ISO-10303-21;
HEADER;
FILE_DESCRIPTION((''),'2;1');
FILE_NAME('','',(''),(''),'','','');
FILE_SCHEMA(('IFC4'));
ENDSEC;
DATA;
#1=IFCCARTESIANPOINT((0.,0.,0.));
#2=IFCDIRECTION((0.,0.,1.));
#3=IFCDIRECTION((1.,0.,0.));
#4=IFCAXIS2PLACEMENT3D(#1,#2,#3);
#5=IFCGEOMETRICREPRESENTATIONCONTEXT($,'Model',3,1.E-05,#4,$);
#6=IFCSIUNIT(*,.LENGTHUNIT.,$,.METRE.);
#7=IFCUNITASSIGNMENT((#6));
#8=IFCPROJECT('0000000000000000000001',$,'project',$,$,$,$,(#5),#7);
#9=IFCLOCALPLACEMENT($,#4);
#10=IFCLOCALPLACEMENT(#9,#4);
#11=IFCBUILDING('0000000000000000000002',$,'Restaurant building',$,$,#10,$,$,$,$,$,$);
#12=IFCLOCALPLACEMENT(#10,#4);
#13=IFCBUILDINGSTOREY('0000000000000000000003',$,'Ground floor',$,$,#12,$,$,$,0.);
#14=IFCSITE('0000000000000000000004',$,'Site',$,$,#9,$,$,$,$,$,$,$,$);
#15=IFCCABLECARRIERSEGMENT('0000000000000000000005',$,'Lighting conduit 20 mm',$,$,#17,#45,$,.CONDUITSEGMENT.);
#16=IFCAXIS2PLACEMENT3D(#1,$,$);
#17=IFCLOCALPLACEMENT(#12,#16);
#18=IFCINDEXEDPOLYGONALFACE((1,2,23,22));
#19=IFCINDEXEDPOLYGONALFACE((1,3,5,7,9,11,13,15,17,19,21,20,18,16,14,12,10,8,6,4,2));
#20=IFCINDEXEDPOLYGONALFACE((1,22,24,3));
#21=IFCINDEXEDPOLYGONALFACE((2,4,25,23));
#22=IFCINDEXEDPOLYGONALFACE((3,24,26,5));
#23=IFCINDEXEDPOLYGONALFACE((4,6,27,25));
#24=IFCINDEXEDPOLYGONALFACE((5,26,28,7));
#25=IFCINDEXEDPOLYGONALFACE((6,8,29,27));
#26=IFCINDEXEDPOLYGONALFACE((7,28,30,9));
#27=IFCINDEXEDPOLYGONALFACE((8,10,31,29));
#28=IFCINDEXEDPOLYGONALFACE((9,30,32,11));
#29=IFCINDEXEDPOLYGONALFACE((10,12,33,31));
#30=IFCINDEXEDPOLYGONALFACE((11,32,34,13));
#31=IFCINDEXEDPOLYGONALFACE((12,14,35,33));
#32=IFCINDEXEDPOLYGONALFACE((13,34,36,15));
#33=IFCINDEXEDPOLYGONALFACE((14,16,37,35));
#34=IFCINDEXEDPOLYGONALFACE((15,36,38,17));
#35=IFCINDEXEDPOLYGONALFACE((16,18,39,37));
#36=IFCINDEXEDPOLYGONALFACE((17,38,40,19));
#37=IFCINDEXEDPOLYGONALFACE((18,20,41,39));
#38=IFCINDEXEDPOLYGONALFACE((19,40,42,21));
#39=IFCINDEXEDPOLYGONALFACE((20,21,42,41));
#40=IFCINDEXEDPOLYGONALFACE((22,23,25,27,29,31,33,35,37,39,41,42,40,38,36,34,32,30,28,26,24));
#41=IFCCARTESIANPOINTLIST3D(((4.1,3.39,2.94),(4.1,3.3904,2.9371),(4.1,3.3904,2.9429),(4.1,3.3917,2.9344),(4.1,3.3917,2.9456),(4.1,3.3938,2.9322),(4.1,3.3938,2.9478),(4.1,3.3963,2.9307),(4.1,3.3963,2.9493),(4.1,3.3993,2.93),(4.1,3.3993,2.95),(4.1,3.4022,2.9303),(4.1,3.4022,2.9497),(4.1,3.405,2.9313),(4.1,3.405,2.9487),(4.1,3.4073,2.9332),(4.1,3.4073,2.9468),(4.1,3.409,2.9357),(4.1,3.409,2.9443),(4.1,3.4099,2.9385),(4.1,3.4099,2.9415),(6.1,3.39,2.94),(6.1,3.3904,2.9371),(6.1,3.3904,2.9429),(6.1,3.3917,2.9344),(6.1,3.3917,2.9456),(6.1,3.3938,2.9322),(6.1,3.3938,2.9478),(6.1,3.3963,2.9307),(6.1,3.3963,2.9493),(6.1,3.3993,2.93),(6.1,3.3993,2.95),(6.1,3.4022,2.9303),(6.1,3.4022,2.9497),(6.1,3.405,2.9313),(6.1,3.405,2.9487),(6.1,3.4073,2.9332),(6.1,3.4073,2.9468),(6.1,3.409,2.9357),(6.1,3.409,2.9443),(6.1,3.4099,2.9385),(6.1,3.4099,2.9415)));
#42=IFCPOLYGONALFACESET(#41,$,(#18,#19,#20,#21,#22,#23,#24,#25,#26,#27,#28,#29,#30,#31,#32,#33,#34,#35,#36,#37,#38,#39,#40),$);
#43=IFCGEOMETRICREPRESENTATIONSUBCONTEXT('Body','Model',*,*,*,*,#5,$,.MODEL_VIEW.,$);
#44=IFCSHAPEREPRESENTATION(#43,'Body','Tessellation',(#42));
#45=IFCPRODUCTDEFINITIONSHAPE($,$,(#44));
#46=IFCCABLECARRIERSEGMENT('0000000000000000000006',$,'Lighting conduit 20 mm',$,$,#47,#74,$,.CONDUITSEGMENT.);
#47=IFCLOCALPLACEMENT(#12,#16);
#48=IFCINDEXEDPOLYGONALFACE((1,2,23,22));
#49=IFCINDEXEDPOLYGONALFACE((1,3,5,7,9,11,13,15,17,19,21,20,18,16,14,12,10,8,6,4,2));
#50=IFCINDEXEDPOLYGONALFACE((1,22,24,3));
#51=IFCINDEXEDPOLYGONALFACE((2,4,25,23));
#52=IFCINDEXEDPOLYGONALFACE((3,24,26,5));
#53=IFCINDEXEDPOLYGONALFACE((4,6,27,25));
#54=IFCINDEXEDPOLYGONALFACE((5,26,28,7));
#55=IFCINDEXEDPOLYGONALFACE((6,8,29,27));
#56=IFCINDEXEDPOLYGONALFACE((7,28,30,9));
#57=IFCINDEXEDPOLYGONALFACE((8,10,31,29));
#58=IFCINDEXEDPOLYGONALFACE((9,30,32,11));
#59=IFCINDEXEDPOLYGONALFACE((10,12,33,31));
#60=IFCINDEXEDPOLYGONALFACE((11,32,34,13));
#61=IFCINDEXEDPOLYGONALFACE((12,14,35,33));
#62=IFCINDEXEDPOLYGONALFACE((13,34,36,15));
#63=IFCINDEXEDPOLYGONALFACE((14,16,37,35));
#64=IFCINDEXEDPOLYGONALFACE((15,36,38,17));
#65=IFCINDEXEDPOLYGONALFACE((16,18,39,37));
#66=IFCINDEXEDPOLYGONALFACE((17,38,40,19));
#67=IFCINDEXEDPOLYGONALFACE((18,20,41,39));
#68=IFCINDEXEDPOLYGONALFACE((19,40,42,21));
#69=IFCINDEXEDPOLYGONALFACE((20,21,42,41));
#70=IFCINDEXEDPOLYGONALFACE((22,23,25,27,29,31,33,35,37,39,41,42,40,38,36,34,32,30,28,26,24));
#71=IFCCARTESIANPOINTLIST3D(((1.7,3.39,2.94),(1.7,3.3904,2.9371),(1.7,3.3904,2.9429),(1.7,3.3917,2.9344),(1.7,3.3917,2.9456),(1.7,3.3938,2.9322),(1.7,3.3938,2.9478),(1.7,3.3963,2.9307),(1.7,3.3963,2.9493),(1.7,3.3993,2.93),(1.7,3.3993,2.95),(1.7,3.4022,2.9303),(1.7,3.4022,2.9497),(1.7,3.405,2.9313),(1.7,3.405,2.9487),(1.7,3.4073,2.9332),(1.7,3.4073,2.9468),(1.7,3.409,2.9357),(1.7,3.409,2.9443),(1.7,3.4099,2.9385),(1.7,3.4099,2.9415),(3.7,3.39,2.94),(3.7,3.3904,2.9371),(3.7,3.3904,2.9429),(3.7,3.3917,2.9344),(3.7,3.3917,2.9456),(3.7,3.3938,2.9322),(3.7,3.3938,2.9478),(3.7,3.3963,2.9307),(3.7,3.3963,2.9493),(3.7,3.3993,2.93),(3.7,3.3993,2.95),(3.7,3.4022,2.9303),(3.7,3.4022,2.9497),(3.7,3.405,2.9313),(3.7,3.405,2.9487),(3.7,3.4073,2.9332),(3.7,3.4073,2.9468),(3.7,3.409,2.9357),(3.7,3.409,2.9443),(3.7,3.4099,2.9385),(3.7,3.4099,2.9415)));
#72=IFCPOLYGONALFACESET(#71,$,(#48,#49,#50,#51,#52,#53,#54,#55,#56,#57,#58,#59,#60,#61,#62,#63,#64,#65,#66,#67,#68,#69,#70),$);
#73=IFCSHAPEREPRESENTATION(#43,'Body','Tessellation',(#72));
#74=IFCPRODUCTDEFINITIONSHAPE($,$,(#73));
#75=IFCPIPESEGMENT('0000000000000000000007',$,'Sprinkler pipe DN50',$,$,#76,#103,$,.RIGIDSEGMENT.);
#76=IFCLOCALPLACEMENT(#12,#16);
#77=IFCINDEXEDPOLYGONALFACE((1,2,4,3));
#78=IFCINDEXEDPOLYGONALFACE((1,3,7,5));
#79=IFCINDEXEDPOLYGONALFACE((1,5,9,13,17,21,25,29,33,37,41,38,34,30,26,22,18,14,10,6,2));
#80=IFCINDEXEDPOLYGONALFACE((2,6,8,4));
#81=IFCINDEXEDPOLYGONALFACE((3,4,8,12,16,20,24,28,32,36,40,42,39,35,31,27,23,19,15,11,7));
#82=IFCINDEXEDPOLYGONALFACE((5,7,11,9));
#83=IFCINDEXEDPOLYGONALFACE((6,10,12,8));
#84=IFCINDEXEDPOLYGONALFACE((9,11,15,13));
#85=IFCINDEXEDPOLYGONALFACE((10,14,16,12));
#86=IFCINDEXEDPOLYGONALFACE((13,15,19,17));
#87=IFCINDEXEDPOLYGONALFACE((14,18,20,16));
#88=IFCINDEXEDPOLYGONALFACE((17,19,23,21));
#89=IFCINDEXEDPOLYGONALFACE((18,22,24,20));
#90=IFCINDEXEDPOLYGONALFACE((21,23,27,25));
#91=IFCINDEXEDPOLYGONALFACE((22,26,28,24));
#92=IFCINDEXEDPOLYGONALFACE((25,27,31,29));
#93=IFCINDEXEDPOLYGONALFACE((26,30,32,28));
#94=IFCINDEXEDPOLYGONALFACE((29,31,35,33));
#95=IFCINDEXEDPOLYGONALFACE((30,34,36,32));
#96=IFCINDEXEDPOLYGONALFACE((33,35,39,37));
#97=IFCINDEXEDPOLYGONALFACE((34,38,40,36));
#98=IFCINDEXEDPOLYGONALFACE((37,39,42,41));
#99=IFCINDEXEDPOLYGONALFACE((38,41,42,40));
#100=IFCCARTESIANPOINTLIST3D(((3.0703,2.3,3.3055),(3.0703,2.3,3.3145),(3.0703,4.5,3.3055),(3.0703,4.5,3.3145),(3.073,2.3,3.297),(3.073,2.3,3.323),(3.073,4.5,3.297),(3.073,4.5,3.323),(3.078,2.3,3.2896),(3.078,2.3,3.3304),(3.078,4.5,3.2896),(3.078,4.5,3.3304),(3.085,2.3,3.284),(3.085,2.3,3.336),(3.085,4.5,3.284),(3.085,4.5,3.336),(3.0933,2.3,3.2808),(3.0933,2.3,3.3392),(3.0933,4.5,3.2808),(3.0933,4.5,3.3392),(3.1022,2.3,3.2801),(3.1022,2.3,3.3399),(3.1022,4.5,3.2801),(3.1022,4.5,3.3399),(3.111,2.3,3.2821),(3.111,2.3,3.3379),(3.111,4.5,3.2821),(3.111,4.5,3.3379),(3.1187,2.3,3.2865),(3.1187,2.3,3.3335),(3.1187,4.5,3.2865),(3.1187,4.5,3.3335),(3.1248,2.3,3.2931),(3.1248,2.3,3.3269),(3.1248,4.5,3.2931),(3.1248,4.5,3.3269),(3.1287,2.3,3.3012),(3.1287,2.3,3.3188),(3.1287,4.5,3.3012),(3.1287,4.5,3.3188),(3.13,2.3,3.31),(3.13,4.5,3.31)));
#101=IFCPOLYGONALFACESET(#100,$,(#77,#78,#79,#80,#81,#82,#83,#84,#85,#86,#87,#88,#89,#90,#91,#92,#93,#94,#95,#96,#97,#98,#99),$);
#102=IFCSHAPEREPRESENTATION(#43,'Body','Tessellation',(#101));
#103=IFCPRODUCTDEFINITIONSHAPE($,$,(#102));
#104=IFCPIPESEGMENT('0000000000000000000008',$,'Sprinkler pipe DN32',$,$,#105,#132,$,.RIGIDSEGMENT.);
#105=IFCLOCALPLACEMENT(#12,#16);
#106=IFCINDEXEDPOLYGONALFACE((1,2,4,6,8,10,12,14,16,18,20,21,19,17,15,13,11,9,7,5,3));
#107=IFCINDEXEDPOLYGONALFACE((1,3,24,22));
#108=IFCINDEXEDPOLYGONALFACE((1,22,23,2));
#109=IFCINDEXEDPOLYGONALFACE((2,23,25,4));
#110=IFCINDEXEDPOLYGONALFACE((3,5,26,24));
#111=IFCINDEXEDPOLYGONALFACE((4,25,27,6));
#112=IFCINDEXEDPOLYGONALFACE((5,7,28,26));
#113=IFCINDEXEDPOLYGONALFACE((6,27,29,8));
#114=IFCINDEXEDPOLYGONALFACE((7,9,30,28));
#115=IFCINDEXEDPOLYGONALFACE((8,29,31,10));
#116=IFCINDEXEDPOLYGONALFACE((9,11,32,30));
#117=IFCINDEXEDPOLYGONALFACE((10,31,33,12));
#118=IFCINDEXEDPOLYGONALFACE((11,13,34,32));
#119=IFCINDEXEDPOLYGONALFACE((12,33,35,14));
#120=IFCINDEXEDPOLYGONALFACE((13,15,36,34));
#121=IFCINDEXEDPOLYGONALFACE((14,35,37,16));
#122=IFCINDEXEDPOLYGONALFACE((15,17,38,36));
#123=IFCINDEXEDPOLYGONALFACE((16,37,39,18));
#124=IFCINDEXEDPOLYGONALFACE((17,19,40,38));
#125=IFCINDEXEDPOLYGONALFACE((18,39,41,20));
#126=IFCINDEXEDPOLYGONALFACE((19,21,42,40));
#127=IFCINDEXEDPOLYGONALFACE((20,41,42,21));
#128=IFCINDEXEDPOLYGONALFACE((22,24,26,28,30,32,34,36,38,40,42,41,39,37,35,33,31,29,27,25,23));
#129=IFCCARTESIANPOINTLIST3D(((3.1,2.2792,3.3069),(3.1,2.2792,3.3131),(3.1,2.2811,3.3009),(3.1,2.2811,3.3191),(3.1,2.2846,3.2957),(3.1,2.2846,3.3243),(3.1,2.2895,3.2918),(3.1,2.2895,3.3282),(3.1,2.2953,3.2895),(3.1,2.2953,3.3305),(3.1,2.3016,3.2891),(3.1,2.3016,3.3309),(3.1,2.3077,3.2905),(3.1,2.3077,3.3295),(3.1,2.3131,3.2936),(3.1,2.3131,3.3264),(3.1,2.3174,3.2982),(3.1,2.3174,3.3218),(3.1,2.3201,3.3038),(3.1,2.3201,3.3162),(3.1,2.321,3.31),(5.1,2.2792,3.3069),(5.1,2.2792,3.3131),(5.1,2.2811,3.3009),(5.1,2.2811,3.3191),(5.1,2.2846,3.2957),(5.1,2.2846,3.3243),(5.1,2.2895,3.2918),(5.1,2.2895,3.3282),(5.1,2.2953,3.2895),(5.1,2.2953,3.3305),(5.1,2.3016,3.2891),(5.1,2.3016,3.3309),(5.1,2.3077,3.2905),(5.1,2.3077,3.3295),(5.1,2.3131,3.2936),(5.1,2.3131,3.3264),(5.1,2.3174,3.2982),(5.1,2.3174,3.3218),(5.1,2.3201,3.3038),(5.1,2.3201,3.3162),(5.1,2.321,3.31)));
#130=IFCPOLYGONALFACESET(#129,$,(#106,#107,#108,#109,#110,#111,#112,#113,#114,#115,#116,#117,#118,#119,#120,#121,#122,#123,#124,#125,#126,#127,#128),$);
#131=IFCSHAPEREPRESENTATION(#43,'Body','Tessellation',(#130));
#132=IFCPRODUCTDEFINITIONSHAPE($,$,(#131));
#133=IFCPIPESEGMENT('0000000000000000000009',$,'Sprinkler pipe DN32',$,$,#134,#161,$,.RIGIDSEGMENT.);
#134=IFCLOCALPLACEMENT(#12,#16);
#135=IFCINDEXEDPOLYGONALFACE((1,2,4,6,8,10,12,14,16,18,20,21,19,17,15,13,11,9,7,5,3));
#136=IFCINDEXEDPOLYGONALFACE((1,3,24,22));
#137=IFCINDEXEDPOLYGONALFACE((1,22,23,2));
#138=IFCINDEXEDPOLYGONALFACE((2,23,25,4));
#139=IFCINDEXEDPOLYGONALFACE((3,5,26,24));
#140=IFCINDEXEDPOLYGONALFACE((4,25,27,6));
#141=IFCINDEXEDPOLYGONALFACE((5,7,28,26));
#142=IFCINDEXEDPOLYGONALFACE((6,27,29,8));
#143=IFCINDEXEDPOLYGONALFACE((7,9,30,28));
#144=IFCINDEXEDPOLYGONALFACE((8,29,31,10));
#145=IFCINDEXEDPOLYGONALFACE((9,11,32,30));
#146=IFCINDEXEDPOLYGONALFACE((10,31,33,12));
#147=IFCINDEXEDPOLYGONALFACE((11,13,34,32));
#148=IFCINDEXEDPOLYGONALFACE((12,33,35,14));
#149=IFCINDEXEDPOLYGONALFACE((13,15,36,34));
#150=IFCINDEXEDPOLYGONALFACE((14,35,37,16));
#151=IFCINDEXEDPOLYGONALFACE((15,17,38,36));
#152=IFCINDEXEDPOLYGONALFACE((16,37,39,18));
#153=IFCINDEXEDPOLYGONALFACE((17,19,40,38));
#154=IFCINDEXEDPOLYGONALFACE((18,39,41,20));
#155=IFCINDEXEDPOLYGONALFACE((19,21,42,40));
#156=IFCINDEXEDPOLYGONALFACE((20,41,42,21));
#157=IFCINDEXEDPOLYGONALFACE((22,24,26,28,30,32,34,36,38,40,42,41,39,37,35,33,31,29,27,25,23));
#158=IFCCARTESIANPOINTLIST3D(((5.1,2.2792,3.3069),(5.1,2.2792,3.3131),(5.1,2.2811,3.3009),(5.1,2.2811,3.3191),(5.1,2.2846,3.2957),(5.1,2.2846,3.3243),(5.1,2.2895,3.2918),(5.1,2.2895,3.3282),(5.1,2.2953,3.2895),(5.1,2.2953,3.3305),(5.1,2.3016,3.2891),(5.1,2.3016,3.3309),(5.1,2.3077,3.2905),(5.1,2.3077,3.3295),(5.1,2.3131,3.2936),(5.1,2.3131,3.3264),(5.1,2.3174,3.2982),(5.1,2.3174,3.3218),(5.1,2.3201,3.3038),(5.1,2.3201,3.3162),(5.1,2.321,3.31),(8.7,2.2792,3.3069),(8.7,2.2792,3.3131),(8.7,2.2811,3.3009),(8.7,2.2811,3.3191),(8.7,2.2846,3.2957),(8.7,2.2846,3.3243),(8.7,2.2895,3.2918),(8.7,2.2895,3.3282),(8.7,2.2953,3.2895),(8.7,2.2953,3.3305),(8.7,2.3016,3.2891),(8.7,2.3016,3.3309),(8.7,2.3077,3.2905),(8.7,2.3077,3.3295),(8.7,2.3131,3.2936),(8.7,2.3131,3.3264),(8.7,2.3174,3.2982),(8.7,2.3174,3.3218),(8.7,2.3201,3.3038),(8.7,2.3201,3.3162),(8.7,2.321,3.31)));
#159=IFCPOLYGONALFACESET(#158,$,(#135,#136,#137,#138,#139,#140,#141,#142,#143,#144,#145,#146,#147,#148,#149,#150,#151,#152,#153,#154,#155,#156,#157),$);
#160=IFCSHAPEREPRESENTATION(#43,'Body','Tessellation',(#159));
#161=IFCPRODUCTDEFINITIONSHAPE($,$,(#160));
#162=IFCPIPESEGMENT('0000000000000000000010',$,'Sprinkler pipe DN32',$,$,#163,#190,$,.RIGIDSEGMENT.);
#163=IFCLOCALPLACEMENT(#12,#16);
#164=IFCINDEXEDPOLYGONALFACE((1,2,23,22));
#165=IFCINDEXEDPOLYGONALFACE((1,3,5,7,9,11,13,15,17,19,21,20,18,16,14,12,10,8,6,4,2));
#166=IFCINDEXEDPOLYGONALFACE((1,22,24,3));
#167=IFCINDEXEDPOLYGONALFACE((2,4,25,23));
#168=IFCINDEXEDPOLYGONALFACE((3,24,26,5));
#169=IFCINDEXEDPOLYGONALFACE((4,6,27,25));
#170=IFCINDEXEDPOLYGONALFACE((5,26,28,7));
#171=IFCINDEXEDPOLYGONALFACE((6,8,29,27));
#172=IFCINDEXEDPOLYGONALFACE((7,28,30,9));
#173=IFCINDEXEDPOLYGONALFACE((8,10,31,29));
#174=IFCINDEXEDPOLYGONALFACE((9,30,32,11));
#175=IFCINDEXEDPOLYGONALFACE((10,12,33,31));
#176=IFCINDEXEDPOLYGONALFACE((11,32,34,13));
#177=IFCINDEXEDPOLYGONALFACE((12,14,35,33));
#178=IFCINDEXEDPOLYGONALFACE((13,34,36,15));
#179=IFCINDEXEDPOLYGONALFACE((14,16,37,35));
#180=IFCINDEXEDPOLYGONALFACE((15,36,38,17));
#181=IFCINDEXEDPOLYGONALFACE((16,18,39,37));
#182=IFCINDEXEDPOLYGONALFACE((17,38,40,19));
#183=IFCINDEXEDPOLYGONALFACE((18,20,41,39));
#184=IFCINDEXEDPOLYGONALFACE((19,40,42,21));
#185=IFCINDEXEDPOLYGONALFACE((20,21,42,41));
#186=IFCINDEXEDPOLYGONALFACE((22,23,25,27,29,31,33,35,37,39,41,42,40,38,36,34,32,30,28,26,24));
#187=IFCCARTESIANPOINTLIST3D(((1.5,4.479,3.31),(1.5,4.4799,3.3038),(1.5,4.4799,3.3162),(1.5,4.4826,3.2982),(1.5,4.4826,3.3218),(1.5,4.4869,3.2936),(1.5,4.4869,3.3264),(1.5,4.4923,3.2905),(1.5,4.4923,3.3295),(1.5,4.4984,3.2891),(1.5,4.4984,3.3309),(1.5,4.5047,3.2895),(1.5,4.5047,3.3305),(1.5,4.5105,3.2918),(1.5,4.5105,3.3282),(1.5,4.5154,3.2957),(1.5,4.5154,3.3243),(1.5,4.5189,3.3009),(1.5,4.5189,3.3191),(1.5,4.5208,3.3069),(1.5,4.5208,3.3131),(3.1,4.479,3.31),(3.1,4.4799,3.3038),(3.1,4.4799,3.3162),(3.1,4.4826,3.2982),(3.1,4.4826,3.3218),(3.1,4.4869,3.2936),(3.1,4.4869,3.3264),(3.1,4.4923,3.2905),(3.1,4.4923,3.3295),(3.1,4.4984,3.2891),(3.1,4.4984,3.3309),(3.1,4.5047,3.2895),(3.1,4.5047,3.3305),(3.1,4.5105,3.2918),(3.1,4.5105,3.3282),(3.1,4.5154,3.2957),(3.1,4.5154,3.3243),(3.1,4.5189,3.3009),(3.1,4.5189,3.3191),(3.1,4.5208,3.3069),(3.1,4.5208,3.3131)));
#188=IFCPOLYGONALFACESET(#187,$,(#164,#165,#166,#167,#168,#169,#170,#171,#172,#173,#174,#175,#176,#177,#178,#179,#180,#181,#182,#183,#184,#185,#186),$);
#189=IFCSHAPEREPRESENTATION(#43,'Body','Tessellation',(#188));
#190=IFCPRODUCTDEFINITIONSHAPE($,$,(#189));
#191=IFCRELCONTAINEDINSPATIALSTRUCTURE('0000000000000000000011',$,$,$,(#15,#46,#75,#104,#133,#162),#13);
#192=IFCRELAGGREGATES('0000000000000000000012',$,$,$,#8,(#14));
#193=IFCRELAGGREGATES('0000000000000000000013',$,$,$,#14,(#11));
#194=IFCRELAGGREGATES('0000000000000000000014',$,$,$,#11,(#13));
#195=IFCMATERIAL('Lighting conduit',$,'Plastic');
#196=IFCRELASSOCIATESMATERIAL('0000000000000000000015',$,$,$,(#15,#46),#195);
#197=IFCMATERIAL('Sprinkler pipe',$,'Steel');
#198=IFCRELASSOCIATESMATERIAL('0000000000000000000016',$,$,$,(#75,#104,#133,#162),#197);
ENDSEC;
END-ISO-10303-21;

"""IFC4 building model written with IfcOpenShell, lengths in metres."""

from ifc_helpers import new_model, si_unit, frame, origin_with_axes, origin_2d, place, context, subcontext, project, spatial, circle, extrude, material, element, save


model = new_model("IFC4")

# Units and contexts
model_context = context("Model", 3, precision=1e-05, world=origin_with_axes())
body_context = subcontext(model_context, "Body", "Model", "MODEL_VIEW")
ifc_project = project(units=[si_unit("LENGTHUNIT", "METRE")], contexts=[model_context])

# Site, building, storey
site_placement = place(None, origin_with_axes())
site = spatial("IfcSite", under=ifc_project, at=site_placement, Name="Site")
building_placement = place(site_placement, origin_with_axes())
building = spatial("IfcBuilding", under=site, at=building_placement, Name="Restaurant building")
storey_placement = place(building_placement, origin_with_axes())
storey = spatial("IfcBuildingStorey", under=building, at=storey_placement, Name="Ground floor", Elevation=0.0)

# Cable carrier segments
ifc_material_1 = material(Name="Lighting conduit", Category="Plastic")
for number, where, name in (
    (1, (6.1, 3.4, 2.94), "Lighting conduit 20 mm"),
    (2, (3.7, 3.4, 2.94), "Lighting conduit 20 mm"),
):
    element("IfcCableCarrierSegment", number, at=place(storey_placement, frame(where)), inside=storey, material=ifc_material_1, Name=name, PredefinedType="CONDUITSEGMENT", context=body_context, shape_type="SweptSolid", body=[
        extrude(circle(Radius=0.01, at=origin_2d()), frame((0.0, 0.0, 0.0), z_axis=(-1.0, 0.0, 0.0), x_axis=(0.0, -1.0, 0.0)), (0.0, 0.0, 1.0), 2.0),
    ])

# Pipe segments
ifc_material_2 = material(Name="Sprinkler pipe", Category="Steel")
pipe_segment_1_placement = place(storey_placement, frame((3.1, 4.5, 3.31)))
element("IfcPipeSegment", 3, at=pipe_segment_1_placement, inside=storey, material=ifc_material_2, Name="Sprinkler pipe DN50", PredefinedType="RIGIDSEGMENT", context=body_context, shape_type="SweptSolid", body=[
    extrude(circle(Radius=0.03, at=origin_2d()), frame((0.0, 0.0, 0.0), z_axis=(0.0, -1.0, 0.0), x_axis=(1.0, 0.0, 0.0)), (0.0, 0.0, 1.0), 2.2),
])
pipe_segment_2_placement = place(storey_placement, frame((3.1, 2.3, 3.31)))
element("IfcPipeSegment", 4, at=pipe_segment_2_placement, inside=storey, material=ifc_material_2, Name="Sprinkler pipe DN32", PredefinedType="RIGIDSEGMENT", context=body_context, shape_type="SweptSolid", body=[
    extrude(circle(Radius=0.021, at=origin_2d()), frame((0.0, 0.0, 0.0), z_axis=(1.0, 0.0, 0.0), x_axis=(0.0, 1.0, 0.0)), (0.0, 0.0, 1.0), 2.0),
])
pipe_segment_3_placement = place(storey_placement, frame((5.1, 2.3, 3.31)))
element("IfcPipeSegment", 5, at=pipe_segment_3_placement, inside=storey, material=ifc_material_2, Name="Sprinkler pipe DN32", PredefinedType="RIGIDSEGMENT", context=body_context, shape_type="SweptSolid", body=[
    extrude(circle(Radius=0.021, at=origin_2d()), frame((0.0, 0.0, 0.0), z_axis=(1.0, 0.0, 0.0), x_axis=(0.0, 1.0, 0.0)), (0.0, 0.0, 1.0), 3.6),
])
pipe_segment_4_placement = place(storey_placement, frame((3.1, 4.5, 3.31)))
element("IfcPipeSegment", 6, at=pipe_segment_4_placement, inside=storey, material=ifc_material_2, Name="Sprinkler pipe DN32", PredefinedType="RIGIDSEGMENT", context=body_context, shape_type="SweptSolid", body=[
    extrude(circle(Radius=0.021, at=origin_2d()), frame((0.0, 0.0, 0.0), z_axis=(-1.0, 0.0, 0.0), x_axis=(0.0, -1.0, 0.0)), (0.0, 0.0, 1.0), 1.6),
])

save(model, "model.ifc")
